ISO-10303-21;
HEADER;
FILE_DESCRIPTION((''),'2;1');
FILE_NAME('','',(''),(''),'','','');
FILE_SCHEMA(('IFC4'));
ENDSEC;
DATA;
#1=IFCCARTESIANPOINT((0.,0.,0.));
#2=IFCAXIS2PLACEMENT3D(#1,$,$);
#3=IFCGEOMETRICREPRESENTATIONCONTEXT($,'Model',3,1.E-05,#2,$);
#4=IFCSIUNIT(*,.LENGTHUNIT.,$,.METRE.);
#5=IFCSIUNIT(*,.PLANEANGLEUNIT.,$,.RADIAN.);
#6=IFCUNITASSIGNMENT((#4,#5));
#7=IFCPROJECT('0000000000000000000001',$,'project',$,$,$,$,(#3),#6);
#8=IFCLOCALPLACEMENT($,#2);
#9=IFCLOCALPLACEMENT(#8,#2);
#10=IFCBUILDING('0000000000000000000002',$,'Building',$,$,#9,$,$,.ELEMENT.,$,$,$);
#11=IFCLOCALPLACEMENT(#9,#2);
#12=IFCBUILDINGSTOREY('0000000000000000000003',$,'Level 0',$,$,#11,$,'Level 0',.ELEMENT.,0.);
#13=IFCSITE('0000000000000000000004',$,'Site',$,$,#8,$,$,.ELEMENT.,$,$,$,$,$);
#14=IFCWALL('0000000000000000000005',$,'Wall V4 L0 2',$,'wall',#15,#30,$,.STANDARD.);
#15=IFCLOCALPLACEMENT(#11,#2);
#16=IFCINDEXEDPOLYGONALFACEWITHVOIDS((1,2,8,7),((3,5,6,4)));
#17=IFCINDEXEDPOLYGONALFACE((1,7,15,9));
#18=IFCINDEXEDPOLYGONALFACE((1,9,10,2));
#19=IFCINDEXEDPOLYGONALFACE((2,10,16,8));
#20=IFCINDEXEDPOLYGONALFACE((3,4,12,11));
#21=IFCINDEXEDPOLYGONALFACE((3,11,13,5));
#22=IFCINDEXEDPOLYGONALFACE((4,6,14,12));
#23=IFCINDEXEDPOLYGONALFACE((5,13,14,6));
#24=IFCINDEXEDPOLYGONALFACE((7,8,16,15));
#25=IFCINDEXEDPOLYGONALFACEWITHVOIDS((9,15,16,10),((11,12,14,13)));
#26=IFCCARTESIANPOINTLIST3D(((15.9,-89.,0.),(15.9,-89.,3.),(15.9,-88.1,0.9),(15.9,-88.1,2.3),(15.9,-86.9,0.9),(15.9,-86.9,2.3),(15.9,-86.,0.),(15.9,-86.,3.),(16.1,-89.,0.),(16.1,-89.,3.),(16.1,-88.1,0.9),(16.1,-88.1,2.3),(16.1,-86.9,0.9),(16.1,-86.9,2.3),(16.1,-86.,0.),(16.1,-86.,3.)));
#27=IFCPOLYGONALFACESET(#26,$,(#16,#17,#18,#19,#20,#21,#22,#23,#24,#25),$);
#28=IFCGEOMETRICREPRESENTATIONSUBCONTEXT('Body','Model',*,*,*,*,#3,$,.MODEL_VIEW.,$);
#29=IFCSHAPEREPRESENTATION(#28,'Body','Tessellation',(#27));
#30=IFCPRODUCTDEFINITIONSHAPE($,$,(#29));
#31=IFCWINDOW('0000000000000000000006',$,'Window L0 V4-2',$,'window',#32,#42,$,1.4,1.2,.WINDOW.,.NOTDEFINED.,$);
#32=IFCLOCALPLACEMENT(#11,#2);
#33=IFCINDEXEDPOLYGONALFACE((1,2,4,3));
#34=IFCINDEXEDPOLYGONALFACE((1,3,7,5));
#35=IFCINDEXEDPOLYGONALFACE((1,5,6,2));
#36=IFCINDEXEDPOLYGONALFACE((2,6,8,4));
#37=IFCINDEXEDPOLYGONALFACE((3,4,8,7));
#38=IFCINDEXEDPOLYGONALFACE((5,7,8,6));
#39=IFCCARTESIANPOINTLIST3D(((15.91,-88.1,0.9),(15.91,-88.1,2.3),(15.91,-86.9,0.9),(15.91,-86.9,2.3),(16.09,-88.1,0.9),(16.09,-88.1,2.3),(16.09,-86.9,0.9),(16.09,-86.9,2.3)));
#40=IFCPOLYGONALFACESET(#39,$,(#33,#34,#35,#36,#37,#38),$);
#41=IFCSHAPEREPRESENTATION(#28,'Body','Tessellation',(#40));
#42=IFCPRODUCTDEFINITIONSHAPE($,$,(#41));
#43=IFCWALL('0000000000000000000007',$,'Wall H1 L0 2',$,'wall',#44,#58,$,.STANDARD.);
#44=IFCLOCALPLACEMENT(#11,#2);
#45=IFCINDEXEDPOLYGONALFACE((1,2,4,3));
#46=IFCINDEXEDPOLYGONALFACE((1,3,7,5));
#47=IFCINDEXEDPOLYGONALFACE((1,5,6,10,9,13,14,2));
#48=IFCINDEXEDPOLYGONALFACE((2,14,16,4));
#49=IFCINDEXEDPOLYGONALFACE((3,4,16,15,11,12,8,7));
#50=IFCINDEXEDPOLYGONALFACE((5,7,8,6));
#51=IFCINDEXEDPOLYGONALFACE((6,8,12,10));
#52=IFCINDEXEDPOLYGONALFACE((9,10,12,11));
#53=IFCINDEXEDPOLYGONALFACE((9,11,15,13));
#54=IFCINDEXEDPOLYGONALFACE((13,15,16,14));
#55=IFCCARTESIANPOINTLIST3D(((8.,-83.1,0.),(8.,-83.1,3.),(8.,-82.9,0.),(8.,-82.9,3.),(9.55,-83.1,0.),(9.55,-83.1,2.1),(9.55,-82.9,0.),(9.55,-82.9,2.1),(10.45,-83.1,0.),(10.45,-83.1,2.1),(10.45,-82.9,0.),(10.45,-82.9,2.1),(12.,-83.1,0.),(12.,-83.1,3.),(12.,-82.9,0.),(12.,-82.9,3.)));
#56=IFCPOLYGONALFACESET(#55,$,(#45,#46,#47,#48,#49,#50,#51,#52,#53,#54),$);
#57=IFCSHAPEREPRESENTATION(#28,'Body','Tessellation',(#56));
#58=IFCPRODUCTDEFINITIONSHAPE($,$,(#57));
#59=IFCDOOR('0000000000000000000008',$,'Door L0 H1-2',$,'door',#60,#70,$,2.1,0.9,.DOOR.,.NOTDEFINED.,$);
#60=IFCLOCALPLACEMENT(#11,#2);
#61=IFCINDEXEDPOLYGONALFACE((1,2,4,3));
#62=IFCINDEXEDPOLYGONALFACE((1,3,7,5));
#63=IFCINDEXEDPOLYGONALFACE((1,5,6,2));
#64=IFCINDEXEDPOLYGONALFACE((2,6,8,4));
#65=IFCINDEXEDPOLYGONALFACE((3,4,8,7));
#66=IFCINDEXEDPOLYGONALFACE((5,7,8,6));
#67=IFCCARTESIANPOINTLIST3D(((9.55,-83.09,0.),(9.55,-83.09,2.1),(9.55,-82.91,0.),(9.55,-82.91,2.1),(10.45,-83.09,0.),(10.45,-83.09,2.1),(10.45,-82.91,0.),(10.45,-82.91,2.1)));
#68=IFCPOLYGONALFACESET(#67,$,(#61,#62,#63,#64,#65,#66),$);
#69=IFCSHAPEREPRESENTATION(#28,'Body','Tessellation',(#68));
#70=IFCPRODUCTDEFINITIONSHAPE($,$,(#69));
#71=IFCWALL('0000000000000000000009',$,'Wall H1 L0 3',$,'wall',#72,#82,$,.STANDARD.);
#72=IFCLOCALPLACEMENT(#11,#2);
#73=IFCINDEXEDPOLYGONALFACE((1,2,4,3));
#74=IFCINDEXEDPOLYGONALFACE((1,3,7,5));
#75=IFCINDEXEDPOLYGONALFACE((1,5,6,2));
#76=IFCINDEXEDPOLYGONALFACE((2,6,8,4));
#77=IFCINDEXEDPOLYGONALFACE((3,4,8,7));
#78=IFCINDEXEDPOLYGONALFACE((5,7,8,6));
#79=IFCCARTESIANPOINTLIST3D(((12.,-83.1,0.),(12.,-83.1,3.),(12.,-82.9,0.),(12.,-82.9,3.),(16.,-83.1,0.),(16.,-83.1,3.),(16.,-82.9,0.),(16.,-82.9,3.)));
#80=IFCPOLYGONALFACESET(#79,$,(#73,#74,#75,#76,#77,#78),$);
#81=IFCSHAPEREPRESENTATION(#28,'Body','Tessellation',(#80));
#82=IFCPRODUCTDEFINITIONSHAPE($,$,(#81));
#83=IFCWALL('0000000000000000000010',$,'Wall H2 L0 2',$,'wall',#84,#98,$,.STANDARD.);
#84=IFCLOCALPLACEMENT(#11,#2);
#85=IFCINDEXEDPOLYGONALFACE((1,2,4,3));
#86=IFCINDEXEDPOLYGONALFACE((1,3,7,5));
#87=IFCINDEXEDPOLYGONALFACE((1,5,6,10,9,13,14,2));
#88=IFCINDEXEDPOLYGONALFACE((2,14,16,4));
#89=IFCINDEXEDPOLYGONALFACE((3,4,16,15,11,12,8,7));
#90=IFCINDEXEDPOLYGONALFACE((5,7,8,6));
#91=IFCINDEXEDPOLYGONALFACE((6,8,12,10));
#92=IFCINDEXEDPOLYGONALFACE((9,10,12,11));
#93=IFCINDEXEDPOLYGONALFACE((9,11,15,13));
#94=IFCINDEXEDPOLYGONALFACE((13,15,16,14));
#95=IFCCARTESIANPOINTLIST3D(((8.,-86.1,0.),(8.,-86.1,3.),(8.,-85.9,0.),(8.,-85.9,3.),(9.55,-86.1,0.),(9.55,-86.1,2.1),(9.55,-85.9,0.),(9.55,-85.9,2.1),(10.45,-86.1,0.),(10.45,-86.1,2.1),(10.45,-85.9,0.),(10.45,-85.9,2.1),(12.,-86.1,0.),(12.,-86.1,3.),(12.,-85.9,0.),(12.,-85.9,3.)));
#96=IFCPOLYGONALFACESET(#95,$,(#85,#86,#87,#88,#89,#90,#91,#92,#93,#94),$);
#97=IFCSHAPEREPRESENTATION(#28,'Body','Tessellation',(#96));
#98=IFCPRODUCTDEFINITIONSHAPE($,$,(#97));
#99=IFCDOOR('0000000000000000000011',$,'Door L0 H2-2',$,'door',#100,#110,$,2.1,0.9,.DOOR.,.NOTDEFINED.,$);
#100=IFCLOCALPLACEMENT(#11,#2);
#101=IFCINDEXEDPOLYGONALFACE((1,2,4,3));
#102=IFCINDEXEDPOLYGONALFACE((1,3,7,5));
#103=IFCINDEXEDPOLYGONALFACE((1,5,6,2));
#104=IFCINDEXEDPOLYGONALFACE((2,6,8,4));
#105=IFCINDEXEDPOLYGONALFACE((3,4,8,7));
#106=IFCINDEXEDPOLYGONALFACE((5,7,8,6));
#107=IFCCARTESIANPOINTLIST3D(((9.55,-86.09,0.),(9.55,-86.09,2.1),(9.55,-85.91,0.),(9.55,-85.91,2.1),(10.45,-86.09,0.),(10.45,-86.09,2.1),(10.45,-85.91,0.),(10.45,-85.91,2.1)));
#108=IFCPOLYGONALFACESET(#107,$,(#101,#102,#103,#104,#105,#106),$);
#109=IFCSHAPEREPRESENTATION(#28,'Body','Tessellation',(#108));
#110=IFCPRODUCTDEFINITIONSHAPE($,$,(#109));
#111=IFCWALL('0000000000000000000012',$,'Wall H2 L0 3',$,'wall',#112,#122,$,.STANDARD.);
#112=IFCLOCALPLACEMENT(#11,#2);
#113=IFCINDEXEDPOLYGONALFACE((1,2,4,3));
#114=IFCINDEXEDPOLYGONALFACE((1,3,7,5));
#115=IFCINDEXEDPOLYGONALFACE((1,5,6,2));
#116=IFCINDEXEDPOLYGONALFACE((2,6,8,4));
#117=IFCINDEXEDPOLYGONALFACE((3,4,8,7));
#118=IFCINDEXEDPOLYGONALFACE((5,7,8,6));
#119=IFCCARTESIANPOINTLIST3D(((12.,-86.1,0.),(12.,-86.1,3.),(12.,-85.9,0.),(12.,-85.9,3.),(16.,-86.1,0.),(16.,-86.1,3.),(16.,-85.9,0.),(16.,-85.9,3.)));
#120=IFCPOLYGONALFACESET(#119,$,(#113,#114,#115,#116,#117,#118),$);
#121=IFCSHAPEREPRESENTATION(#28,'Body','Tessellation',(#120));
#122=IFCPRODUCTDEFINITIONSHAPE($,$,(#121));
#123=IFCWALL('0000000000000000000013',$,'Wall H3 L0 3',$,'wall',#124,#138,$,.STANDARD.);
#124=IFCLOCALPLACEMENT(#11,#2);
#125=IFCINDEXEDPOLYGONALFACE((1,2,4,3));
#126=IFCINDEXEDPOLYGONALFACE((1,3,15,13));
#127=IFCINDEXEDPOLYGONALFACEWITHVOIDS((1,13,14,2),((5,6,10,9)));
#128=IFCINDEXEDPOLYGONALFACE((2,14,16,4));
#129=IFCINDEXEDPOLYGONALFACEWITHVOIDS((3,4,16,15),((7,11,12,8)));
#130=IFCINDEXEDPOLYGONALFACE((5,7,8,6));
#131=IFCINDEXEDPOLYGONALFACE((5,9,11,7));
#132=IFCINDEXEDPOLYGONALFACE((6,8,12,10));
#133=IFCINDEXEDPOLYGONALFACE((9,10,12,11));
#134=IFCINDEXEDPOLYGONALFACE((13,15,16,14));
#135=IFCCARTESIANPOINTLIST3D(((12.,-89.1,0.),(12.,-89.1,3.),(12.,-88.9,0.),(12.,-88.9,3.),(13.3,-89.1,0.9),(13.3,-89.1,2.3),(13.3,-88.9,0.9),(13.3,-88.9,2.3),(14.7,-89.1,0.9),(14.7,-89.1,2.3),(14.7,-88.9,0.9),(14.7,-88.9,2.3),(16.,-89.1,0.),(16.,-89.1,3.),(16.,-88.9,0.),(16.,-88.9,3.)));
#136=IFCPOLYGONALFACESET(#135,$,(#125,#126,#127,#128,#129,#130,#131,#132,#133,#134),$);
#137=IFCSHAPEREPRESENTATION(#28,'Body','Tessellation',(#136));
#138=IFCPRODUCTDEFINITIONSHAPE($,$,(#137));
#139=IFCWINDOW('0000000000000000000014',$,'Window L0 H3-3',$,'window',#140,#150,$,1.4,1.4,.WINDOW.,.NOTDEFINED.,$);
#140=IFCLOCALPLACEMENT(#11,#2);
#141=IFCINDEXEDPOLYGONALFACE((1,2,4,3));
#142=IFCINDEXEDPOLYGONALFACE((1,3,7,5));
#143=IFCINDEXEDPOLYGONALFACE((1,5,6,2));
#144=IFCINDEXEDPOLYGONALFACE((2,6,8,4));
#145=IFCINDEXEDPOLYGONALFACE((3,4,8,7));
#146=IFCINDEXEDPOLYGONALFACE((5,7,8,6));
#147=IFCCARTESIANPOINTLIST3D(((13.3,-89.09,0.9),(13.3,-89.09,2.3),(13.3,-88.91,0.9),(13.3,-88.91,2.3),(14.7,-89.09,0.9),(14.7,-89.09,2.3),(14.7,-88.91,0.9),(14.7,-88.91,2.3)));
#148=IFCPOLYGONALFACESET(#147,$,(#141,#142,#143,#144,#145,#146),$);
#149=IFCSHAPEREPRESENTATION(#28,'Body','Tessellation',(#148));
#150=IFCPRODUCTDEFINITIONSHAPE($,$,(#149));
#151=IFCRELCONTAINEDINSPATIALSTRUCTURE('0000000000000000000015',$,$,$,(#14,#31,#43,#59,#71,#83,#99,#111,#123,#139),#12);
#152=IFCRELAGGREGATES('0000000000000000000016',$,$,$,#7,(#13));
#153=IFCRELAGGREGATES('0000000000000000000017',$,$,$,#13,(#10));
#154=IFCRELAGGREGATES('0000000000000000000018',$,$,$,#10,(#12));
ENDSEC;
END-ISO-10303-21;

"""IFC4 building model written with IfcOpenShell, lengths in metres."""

from ifc_helpers import new_model, si_unit, frame, frame_2d, origin, origin_2d, place, context, subcontext, project, spatial, rectangle, extrude, element, fill, save


model = new_model("IFC4")

# Units and contexts
model_context = context("Model", 3, precision=1e-05, world=origin())
body_context = subcontext(model_context, "Body", "Model", "MODEL_VIEW")
ifc_project = project(units=[si_unit("LENGTHUNIT", "METRE"), si_unit("PLANEANGLEUNIT", "RADIAN")], contexts=[model_context])

# Site, building, storey
site_placement = place(None, origin())
site = spatial("IfcSite", under=ifc_project, at=site_placement, Name="Site", CompositionType="ELEMENT")
building_placement = place(site_placement, origin())
building = spatial("IfcBuilding", under=site, at=building_placement, Name="Building", CompositionType="ELEMENT")
storey_placement = place(building_placement, origin())
storey = spatial("IfcBuildingStorey", under=building, at=storey_placement, Name="Level 0", LongName="Level 0", CompositionType="ELEMENT", Elevation=0.0)

# Wall, opening, window
wall_1_placement = place(storey_placement, frame((16.0, -86.0, 0.0), z_axis=(0.0, 0.0, 1.0), x_axis=(0.0, -1.0, 0.0)))
wall_1 = element("IfcWall", 1, at=wall_1_placement, inside=storey, Name="Wall V4 L0 2", ObjectType="wall", PredefinedType="STANDARD", context=body_context, shape_type="SweptSolid", body=[
    extrude(rectangle(XDim=3.0, YDim=0.2, at=frame_2d((1.5, 0.0))), origin(), (0.0, 0.0, 1.0), 3.0),
])
opening_1_placement = place(storey_placement, frame((16.0, -87.5, 0.9), z_axis=(0.0, 0.0, 1.0), x_axis=(0.0, -1.0, 0.0)))
opening_1 = element("IfcOpeningElement", 2, at=opening_1_placement, cuts=wall_1, ObjectType="Opening", PredefinedType="OPENING", context=body_context, shape_type="SweptSolid", body=[
    extrude(rectangle(XDim=1.2, YDim=0.22, at=origin_2d()), origin(), (0.0, 0.0, 1.0), 1.4),
])
window_1_placement = place(storey_placement, frame((16.0, -87.5, 0.9), z_axis=(0.0, 0.0, 1.0), x_axis=(0.0, -1.0, 0.0)))
window_1 = element("IfcWindow", 3, at=window_1_placement, inside=storey, Name="Window L0 V4-2", ObjectType="window", OverallHeight=1.4, OverallWidth=1.2, PartitioningType="NOTDEFINED", PredefinedType="WINDOW", context=body_context, shape_type="SweptSolid", body=[
    extrude(rectangle(XDim=1.2, YDim=0.18, at=origin_2d()), origin(), (0.0, 0.0, 1.0), 1.4),
])
fill(opening_1, window_1)

# Wall, opening, door
wall_2_placement = place(storey_placement, frame((8.0, -83.0, 0.0), z_axis=(0.0, 0.0, 1.0), x_axis=(1.0, 0.0, 0.0)))
wall_2 = element("IfcWall", 4, at=wall_2_placement, inside=storey, Name="Wall H1 L0 2", ObjectType="wall", PredefinedType="STANDARD", context=body_context, shape_type="SweptSolid", body=[
    extrude(rectangle(XDim=4.0, YDim=0.2, at=frame_2d((2.0, 0.0))), origin(), (0.0, 0.0, 1.0), 3.0),
])
opening_2_placement = place(storey_placement, frame((10.0, -83.0, 0.0), z_axis=(0.0, 0.0, 1.0), x_axis=(1.0, 0.0, 0.0)))
opening_2 = element("IfcOpeningElement", 5, at=opening_2_placement, cuts=wall_2, ObjectType="Opening", PredefinedType="OPENING", context=body_context, shape_type="SweptSolid", body=[
    extrude(rectangle(XDim=0.9, YDim=0.22, at=origin_2d()), origin(), (0.0, 0.0, 1.0), 2.1),
])
door_1_placement = place(storey_placement, frame((10.0, -83.0, 0.0), z_axis=(0.0, 0.0, 1.0), x_axis=(1.0, 0.0, 0.0)))
door_1 = element("IfcDoor", 6, at=door_1_placement, inside=storey, Name="Door L0 H1-2", ObjectType="door", OperationType="NOTDEFINED", OverallHeight=2.1, OverallWidth=0.9, PredefinedType="DOOR", context=body_context, shape_type="SweptSolid", body=[
    extrude(rectangle(XDim=0.9, YDim=0.18, at=origin_2d()), origin(), (0.0, 0.0, 1.0), 2.1),
])
fill(opening_2, door_1)

# Wall
wall_3_placement = place(storey_placement, frame((12.0, -83.0, 0.0), z_axis=(0.0, 0.0, 1.0), x_axis=(1.0, 0.0, 0.0)))
element("IfcWall", 7, at=wall_3_placement, inside=storey, Name="Wall H1 L0 3", ObjectType="wall", PredefinedType="STANDARD", context=body_context, shape_type="SweptSolid", body=[
    extrude(rectangle(XDim=4.0, YDim=0.2, at=frame_2d((2.0, 0.0))), origin(), (0.0, 0.0, 1.0), 3.0),
])

# Wall, opening, door
wall_4_placement = place(storey_placement, frame((8.0, -86.0, 0.0), z_axis=(0.0, 0.0, 1.0), x_axis=(1.0, 0.0, 0.0)))
wall_4 = element("IfcWall", 8, at=wall_4_placement, inside=storey, Name="Wall H2 L0 2", ObjectType="wall", PredefinedType="STANDARD", context=body_context, shape_type="SweptSolid", body=[
    extrude(rectangle(XDim=4.0, YDim=0.2, at=frame_2d((2.0, 0.0))), origin(), (0.0, 0.0, 1.0), 3.0),
])
opening_3_placement = place(storey_placement, frame((10.0, -86.0, 0.0), z_axis=(0.0, 0.0, 1.0), x_axis=(1.0, 0.0, 0.0)))
opening_3 = element("IfcOpeningElement", 9, at=opening_3_placement, cuts=wall_4, ObjectType="Opening", PredefinedType="OPENING", context=body_context, shape_type="SweptSolid", body=[
    extrude(rectangle(XDim=0.9, YDim=0.22, at=origin_2d()), origin(), (0.0, 0.0, 1.0), 2.1),
])
door_2_placement = place(storey_placement, frame((10.0, -86.0, 0.0), z_axis=(0.0, 0.0, 1.0), x_axis=(1.0, 0.0, 0.0)))
door_2 = element("IfcDoor", 10, at=door_2_placement, inside=storey, Name="Door L0 H2-2", ObjectType="door", OperationType="NOTDEFINED", OverallHeight=2.1, OverallWidth=0.9, PredefinedType="DOOR", context=body_context, shape_type="SweptSolid", body=[
    extrude(rectangle(XDim=0.9, YDim=0.18, at=origin_2d()), origin(), (0.0, 0.0, 1.0), 2.1),
])
fill(opening_3, door_2)

# Wall
wall_5_placement = place(storey_placement, frame((12.0, -86.0, 0.0), z_axis=(0.0, 0.0, 1.0), x_axis=(1.0, 0.0, 0.0)))
element("IfcWall", 11, at=wall_5_placement, inside=storey, Name="Wall H2 L0 3", ObjectType="wall", PredefinedType="STANDARD", context=body_context, shape_type="SweptSolid", body=[
    extrude(rectangle(XDim=4.0, YDim=0.2, at=frame_2d((2.0, 0.0))), origin(), (0.0, 0.0, 1.0), 3.0),
])

# Wall, opening, window
wall_6_placement = place(storey_placement, frame((12.0, -89.0, 0.0), z_axis=(0.0, 0.0, 1.0), x_axis=(1.0, 0.0, 0.0)))
wall_6 = element("IfcWall", 12, at=wall_6_placement, inside=storey, Name="Wall H3 L0 3", ObjectType="wall", PredefinedType="STANDARD", context=body_context, shape_type="SweptSolid", body=[
    extrude(rectangle(XDim=4.0, YDim=0.2, at=frame_2d((2.0, 0.0))), origin(), (0.0, 0.0, 1.0), 3.0),
])
opening_4_placement = place(storey_placement, frame((14.0, -89.0, 0.9), z_axis=(0.0, 0.0, 1.0), x_axis=(1.0, 0.0, 0.0)))
opening_4 = element("IfcOpeningElement", 13, at=opening_4_placement, cuts=wall_6, ObjectType="Opening", PredefinedType="OPENING", context=body_context, shape_type="SweptSolid", body=[
    extrude(rectangle(XDim=1.4, YDim=0.22, at=origin_2d()), origin(), (0.0, 0.0, 1.0), 1.4),
])
window_2_placement = place(storey_placement, frame((14.0, -89.0, 0.9), z_axis=(0.0, 0.0, 1.0), x_axis=(1.0, 0.0, 0.0)))
window_2 = element("IfcWindow", 14, at=window_2_placement, inside=storey, Name="Window L0 H3-3", ObjectType="window", OverallHeight=1.4, OverallWidth=1.4, PartitioningType="NOTDEFINED", PredefinedType="WINDOW", context=body_context, shape_type="SweptSolid", body=[
    extrude(rectangle(XDim=1.4, YDim=0.18, at=origin_2d()), origin(), (0.0, 0.0, 1.0), 1.4),
])
fill(opening_4, window_2)

save(model, "model.ifc")
